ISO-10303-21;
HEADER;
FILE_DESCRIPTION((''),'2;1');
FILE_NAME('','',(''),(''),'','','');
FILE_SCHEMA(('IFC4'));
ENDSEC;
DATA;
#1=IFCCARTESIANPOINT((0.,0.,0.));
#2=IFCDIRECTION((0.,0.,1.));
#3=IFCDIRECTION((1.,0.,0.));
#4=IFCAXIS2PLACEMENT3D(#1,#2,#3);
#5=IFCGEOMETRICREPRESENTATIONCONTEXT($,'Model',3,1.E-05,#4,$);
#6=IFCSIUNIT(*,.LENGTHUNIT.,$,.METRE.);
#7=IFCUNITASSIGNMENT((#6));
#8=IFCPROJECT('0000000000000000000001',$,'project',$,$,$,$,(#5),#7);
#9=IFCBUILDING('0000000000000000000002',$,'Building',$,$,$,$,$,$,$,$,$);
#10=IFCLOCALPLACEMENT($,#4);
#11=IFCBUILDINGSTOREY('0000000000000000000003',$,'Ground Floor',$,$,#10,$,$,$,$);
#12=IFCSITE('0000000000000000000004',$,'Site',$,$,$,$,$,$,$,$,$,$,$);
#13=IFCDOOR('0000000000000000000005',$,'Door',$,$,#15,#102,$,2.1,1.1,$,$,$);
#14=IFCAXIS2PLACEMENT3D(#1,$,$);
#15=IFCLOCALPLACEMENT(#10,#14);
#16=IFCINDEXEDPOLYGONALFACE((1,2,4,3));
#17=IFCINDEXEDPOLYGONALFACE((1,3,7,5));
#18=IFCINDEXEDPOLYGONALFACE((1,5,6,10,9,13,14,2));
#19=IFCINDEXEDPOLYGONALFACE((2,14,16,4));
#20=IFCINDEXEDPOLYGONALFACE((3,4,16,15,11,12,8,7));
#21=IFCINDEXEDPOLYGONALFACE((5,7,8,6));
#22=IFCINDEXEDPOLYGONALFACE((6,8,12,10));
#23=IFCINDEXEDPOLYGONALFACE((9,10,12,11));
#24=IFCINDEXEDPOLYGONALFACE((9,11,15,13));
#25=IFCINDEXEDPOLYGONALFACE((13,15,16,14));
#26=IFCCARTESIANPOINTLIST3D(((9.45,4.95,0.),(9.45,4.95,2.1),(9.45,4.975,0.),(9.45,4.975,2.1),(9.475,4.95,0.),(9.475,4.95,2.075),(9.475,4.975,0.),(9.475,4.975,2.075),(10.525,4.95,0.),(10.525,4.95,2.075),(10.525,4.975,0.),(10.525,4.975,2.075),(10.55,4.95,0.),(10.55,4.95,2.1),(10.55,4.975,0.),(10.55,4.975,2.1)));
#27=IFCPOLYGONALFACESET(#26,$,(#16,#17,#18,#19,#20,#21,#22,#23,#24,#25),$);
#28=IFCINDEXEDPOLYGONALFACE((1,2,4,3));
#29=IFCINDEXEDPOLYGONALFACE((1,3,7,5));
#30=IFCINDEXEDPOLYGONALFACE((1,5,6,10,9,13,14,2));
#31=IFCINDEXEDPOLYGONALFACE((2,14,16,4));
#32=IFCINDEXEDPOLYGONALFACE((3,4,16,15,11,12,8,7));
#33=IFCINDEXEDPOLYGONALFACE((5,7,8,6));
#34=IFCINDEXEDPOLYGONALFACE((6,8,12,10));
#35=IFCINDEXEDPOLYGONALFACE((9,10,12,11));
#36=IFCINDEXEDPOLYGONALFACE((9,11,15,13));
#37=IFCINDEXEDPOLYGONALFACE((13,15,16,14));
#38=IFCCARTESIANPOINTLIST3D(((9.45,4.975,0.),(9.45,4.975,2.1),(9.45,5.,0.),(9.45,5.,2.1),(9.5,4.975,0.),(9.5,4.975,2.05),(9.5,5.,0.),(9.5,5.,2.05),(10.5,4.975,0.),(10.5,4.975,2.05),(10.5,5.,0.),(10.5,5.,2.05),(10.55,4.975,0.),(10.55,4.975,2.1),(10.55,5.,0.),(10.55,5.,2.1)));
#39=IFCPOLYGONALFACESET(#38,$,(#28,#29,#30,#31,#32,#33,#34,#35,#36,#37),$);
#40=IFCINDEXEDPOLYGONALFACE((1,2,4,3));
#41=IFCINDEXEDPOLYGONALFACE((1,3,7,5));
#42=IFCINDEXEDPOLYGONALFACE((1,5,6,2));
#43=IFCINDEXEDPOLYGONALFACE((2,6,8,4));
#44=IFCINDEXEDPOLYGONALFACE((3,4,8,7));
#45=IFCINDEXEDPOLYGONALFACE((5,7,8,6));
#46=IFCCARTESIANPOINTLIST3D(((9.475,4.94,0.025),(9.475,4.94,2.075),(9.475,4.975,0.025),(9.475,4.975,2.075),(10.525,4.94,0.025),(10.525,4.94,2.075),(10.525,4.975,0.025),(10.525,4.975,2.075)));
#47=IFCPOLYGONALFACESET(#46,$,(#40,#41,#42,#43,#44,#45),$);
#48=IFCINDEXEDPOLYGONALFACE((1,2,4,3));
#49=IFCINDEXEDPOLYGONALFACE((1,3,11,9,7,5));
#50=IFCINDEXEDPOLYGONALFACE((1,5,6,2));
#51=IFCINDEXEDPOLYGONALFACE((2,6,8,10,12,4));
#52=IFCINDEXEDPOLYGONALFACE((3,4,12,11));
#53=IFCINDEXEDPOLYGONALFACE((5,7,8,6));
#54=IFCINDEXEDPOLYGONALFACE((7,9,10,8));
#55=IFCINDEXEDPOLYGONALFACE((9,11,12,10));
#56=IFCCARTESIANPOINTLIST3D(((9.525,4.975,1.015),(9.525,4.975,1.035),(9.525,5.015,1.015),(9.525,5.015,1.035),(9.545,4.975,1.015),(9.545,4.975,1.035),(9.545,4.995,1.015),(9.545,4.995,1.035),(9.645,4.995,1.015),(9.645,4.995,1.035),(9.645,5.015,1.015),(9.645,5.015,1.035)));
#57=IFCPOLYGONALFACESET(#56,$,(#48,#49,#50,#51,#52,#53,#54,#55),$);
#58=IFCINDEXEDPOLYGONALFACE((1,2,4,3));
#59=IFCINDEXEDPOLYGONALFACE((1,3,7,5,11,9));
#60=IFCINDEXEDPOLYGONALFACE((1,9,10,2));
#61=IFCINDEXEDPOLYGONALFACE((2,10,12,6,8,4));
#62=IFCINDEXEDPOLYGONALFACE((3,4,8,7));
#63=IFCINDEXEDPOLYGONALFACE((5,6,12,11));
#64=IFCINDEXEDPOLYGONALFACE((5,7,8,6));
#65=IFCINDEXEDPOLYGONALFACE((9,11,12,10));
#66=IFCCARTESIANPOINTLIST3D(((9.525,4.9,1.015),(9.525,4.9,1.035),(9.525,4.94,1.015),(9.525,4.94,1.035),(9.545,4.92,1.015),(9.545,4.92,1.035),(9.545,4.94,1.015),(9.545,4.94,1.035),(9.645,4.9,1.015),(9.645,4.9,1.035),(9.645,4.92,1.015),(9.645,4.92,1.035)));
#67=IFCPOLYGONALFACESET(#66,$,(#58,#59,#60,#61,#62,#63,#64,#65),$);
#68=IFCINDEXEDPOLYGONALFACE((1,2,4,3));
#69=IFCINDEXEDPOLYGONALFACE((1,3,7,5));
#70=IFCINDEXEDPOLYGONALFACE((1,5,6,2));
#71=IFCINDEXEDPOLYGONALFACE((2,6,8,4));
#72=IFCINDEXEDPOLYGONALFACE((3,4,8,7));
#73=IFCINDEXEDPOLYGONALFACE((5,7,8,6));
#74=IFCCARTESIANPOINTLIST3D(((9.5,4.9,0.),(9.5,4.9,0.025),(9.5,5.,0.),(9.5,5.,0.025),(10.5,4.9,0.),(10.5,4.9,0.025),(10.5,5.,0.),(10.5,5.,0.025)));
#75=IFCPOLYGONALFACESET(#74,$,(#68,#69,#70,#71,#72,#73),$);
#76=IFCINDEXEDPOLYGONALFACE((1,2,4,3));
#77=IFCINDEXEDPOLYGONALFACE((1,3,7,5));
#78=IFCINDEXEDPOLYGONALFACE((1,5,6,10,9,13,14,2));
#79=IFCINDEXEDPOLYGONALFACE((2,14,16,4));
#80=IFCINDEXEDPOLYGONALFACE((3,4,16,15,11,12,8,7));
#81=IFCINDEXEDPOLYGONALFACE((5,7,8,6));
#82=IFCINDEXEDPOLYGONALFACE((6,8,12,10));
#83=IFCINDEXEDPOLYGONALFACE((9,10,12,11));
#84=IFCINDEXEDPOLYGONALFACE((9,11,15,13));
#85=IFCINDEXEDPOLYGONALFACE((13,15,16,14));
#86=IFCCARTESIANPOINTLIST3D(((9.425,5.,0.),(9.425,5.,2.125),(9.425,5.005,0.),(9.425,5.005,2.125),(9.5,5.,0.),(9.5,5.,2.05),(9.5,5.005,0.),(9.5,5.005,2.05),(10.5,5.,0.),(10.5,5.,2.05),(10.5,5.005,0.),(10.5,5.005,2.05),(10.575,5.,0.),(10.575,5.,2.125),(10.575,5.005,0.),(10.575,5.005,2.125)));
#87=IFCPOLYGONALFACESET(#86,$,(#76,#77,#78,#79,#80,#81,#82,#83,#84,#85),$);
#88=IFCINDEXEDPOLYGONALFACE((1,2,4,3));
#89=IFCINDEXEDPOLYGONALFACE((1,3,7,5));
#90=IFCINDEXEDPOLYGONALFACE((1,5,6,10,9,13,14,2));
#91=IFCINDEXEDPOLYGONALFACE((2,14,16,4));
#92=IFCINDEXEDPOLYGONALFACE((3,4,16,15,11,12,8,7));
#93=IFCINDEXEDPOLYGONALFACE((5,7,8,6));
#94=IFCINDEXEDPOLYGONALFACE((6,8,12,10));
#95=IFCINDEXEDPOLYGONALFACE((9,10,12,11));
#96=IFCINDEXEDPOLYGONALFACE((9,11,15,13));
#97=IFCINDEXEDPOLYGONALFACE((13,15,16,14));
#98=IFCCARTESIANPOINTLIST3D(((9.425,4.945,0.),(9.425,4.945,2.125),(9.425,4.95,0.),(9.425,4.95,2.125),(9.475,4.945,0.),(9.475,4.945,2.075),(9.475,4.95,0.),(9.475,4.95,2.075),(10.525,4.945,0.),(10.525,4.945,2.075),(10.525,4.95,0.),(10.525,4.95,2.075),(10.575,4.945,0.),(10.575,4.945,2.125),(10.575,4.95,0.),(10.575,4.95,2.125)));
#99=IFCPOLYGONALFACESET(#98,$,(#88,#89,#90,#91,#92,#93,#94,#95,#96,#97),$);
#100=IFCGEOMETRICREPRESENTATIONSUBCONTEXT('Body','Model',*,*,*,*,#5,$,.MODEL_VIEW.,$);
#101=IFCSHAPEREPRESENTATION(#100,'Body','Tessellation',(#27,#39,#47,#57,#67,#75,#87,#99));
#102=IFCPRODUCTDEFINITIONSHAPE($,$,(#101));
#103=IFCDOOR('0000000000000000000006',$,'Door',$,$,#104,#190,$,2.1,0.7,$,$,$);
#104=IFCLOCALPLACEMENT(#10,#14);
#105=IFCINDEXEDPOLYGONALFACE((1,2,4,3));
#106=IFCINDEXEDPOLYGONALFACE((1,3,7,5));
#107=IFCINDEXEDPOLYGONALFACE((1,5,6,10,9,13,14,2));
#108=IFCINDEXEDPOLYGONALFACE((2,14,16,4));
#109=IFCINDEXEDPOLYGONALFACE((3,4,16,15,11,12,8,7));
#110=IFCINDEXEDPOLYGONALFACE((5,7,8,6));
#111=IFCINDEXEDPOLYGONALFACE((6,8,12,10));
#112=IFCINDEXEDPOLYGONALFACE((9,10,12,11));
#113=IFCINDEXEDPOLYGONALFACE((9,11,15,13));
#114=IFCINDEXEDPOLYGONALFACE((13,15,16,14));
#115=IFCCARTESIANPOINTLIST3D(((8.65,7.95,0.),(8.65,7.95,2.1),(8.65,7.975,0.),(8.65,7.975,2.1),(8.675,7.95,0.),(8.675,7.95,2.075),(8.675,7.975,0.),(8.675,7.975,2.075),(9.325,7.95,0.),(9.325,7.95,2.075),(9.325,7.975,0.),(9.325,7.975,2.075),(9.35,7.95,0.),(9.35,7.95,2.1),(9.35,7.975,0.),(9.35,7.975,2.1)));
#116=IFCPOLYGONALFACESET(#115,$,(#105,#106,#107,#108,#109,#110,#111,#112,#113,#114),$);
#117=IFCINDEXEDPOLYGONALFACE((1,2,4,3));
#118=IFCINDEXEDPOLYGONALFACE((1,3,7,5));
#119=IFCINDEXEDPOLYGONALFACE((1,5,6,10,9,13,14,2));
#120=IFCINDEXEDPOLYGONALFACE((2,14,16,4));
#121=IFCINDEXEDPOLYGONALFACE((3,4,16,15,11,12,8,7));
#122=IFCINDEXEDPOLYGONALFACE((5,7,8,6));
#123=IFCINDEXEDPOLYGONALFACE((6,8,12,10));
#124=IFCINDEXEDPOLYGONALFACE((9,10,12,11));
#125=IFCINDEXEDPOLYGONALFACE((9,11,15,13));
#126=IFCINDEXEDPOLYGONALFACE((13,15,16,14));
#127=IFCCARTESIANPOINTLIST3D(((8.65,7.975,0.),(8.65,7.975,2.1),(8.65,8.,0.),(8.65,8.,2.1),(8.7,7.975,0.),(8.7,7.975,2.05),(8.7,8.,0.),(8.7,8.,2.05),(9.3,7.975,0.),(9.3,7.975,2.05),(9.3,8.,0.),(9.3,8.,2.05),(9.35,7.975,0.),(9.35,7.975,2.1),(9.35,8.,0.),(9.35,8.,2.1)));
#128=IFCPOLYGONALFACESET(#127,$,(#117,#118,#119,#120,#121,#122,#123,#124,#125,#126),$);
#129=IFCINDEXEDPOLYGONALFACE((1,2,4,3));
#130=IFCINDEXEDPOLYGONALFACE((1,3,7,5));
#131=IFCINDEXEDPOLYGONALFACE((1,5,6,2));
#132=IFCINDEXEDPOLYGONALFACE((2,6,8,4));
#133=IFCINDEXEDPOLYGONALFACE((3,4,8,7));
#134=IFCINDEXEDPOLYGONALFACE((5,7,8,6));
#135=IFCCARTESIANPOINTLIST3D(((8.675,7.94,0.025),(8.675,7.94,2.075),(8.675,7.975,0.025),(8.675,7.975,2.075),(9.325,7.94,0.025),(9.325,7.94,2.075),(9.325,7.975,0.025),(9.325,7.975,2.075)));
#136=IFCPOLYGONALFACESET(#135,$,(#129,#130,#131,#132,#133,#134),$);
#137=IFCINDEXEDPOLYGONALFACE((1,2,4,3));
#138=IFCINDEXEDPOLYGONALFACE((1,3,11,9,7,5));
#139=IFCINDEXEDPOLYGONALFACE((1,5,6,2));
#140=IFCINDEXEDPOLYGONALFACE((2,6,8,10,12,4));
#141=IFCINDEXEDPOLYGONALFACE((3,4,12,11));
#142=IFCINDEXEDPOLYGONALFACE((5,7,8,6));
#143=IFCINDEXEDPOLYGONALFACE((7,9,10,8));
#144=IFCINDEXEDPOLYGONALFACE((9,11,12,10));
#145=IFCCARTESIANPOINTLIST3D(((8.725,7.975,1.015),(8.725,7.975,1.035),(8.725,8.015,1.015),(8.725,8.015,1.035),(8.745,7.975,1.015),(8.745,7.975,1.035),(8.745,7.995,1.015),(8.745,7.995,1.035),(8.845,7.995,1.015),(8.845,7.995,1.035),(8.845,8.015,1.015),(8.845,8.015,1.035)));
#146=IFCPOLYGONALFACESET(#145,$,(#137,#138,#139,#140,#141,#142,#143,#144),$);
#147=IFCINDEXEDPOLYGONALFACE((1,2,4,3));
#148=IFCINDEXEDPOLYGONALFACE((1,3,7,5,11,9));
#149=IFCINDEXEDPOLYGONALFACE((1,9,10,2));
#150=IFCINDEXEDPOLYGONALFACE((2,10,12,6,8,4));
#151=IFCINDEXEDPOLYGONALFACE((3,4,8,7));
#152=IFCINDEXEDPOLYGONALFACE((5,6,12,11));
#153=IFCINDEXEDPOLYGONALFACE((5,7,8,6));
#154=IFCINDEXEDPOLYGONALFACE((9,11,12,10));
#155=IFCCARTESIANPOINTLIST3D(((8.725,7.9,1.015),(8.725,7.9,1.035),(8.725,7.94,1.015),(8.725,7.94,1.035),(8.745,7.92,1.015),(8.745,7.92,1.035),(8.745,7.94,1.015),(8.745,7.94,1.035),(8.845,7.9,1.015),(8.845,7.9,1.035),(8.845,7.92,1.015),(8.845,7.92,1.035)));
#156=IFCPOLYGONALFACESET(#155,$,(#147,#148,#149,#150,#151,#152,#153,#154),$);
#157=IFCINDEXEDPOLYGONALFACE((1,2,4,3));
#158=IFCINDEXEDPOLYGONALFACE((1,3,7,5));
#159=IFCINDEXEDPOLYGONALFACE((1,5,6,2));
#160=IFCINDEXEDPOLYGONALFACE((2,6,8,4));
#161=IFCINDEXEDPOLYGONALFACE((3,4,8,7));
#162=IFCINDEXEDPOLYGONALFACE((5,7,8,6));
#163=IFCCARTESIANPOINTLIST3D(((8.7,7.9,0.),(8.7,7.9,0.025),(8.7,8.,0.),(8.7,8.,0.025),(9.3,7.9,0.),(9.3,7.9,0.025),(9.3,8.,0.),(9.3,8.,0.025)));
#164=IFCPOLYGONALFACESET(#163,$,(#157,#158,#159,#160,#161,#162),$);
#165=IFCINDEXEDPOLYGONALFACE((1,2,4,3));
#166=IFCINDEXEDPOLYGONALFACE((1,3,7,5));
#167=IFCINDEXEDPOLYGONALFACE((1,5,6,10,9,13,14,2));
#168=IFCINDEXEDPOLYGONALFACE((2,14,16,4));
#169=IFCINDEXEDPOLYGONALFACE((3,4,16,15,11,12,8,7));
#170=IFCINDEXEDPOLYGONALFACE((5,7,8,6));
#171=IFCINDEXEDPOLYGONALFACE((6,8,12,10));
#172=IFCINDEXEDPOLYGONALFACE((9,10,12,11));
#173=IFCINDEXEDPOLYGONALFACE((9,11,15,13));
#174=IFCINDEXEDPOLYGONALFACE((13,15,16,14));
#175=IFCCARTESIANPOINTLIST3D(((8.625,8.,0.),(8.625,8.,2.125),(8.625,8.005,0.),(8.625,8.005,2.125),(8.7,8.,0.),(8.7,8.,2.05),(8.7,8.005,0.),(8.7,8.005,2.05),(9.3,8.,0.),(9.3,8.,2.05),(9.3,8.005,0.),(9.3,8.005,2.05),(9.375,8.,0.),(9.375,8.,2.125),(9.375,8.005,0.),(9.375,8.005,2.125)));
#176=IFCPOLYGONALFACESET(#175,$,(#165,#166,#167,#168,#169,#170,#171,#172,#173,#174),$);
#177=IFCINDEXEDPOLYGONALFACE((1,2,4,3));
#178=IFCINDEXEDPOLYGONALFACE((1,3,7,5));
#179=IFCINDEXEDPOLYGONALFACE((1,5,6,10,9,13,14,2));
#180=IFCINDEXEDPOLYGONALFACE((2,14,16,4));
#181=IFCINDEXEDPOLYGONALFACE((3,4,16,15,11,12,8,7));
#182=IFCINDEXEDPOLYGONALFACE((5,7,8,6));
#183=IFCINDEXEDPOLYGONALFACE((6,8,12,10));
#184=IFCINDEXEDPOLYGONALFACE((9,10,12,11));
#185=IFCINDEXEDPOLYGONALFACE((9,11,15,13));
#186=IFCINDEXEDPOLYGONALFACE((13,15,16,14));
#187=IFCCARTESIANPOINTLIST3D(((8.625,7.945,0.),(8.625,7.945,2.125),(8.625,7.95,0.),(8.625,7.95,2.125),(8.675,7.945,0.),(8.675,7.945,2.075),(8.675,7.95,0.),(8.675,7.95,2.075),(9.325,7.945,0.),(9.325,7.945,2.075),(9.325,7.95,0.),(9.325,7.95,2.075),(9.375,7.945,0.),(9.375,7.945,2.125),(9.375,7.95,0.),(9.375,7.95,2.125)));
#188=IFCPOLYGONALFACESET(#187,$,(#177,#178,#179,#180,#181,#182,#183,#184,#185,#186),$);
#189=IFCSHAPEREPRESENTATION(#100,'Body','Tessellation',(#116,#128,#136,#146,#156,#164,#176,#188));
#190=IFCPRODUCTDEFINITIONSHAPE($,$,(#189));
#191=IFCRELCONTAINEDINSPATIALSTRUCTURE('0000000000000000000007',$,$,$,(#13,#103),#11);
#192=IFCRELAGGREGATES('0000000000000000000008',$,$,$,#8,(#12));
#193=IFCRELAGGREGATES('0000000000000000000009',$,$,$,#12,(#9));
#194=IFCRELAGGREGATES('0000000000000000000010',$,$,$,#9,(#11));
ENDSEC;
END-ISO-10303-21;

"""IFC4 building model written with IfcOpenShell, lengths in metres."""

from ifc_helpers import new_model, si_unit, frame, origin_with_axes, place, context, subcontext, project, spatial, line, indexed_curve, outline, extrude, element, save


model = new_model("IFC4")

# Units and contexts
model_context = context("Model", 3, precision=1e-05, world=origin_with_axes())
body_context = subcontext(model_context, "Body", "Model", "MODEL_VIEW")
ifc_project = project(units=[si_unit("LENGTHUNIT", "METRE")], contexts=[model_context])

# Site, building, storey
site = spatial("IfcSite", under=ifc_project, Name="Site")
building = spatial("IfcBuilding", under=site, Name="Building")
storey_placement = place(None, origin_with_axes())
storey = spatial("IfcBuildingStorey", under=building, at=storey_placement, Name="Ground Floor")

# Doors
door_1_placement = place(storey_placement, frame((10.55, 5.0, 0.0), z_axis=(0.0, 0.0, 1.0), x_axis=(-1.0, 0.0, 0.0)))
element("IfcDoor", 1, at=door_1_placement, inside=storey, Name="Door", OverallHeight=2.1, OverallWidth=1.1, context=body_context, shape_type="SweptSolid", body=[
    extrude(outline(indexed_curve([(0.0, 0.0), (0.0, 2.1), (1.1, 2.1), (1.1, 0.0), (1.075, 0.0), (1.075, 2.075), (0.025, 2.075), (0.025, 0.0)], segments=[line(1, 2, 3, 4, 5, 6, 7, 8, 1)])), frame((0.0, 0.025, 0.0), z_axis=(0.0, -1.0, 0.0), x_axis=(1.0, 0.0, 0.0)), (0.0, 0.0, -1.0), 0.025),
    extrude(outline(indexed_curve([(0.0, 0.0), (0.0, 2.1), (1.1, 2.1), (1.1, 0.0), (1.05, 0.0), (1.05, 2.05), (0.05, 2.05), (0.05, 0.0)], segments=[line(1, 2, 3, 4, 5, 6, 7, 8, 1)])), frame((0.0, 0.0, 0.0), z_axis=(0.0, -1.0, 0.0), x_axis=(1.0, 0.0, 0.0)), (0.0, 0.0, -1.0), 0.025),
    extrude(outline(indexed_curve([(0.0, 0.0), (1.05, 0.0), (1.05, 0.035), (0.0, 0.035)], segments=[line(1, 2, 3, 4, 1)])), frame((0.025, 0.025, 0.025), z_axis=(0.0, 0.0, 1.0), x_axis=(1.0, 0.0, 0.0)), (0.0, 0.0, 1.0), 2.05),
    extrude(outline(indexed_curve([(0.0, 0.0), (0.0, -0.04), (-0.12, -0.04), (-0.12, -0.02), (-0.02, -0.02), (-0.02, 0.0)], segments=[line(1, 2, 3, 4, 5, 6, 1)])), frame((1.025, 0.025, 1.015), z_axis=(0.0, 0.0, 1.0), x_axis=(1.0, 0.0, 0.0)), (0.0, 0.0, 1.0), 0.02),
    extrude(outline(indexed_curve([(0.0, 0.0), (0.0, 0.04), (-0.12, 0.04), (-0.12, 0.02), (-0.02, 0.02), (-0.02, 0.0)], segments=[line(1, 2, 3, 4, 5, 6, 1)])), frame((1.025, 0.06, 1.015), z_axis=(0.0, 0.0, 1.0), x_axis=(1.0, 0.0, 0.0)), (0.0, 0.0, 1.0), 0.02),
    extrude(outline(indexed_curve([(0.0, 0.0), (1.0, 0.0), (1.0, 0.1), (0.0, 0.1)], segments=[line(1, 2, 3, 4, 1)])), frame((0.05, 0.0, 0.0), z_axis=(0.0, 0.0, 1.0), x_axis=(1.0, 0.0, 0.0)), (0.0, 0.0, 1.0), 0.025),
    extrude(outline(indexed_curve([(0.0, 0.0), (0.0, 2.125), (1.15, 2.125), (1.15, 0.0), (1.075, 0.0), (1.075, 2.05), (0.075, 2.05), (0.075, 0.0)], segments=[line(1, 2, 3, 4, 5, 6, 7, 8, 1)])), frame((-0.025, -0.005, 0.0), z_axis=(0.0, -1.0, 0.0), x_axis=(1.0, 0.0, 0.0)), (0.0, 0.0, -1.0), 0.005),
    extrude(outline(indexed_curve([(0.0, 0.0), (0.0, 2.125), (1.15, 2.125), (1.15, 0.0), (1.1, 0.0), (1.1, 2.075), (0.05, 2.075), (0.05, 0.0)], segments=[line(1, 2, 3, 4, 5, 6, 7, 8, 1)])), frame((-0.025, 0.05, 0.0), z_axis=(0.0, -1.0, 0.0), x_axis=(1.0, 0.0, 0.0)), (0.0, 0.0, -1.0), 0.005),
])
door_2_placement = place(storey_placement, frame((9.35, 8.0, 0.0), z_axis=(0.0, 0.0, 1.0), x_axis=(-1.0, 0.0, 0.0)))
element("IfcDoor", 2, at=door_2_placement, inside=storey, Name="Door", OverallHeight=2.1, OverallWidth=0.7, context=body_context, shape_type="SweptSolid", body=[
    extrude(outline(indexed_curve([(0.0, 0.0), (0.0, 2.1), (0.7, 2.1), (0.7, 0.0), (0.675, 0.0), (0.675, 2.075), (0.025, 2.075), (0.025, 0.0)], segments=[line(1, 2, 3, 4, 5, 6, 7, 8, 1)])), frame((0.0, 0.025, 0.0), z_axis=(0.0, -1.0, 0.0), x_axis=(1.0, 0.0, 0.0)), (0.0, 0.0, -1.0), 0.025),
    extrude(outline(indexed_curve([(0.0, 0.0), (0.0, 2.1), (0.7, 2.1), (0.7, 0.0), (0.65, 0.0), (0.65, 2.05), (0.05, 2.05), (0.05, 0.0)], segments=[line(1, 2, 3, 4, 5, 6, 7, 8, 1)])), frame((0.0, 0.0, 0.0), z_axis=(0.0, -1.0, 0.0), x_axis=(1.0, 0.0, 0.0)), (0.0, 0.0, -1.0), 0.025),
    extrude(outline(indexed_curve([(0.0, 0.0), (0.65, 0.0), (0.65, 0.035), (0.0, 0.035)], segments=[line(1, 2, 3, 4, 1)])), frame((0.025, 0.025, 0.025), z_axis=(0.0, 0.0, 1.0), x_axis=(1.0, 0.0, 0.0)), (0.0, 0.0, 1.0), 2.05),
    extrude(outline(indexed_curve([(0.0, 0.0), (0.0, -0.04), (-0.12, -0.04), (-0.12, -0.02), (-0.02, -0.02), (-0.02, 0.0)], segments=[line(1, 2, 3, 4, 5, 6, 1)])), frame((0.625, 0.025, 1.015), z_axis=(0.0, 0.0, 1.0), x_axis=(1.0, 0.0, 0.0)), (0.0, 0.0, 1.0), 0.02),
    extrude(outline(indexed_curve([(0.0, 0.0), (0.0, 0.04), (-0.12, 0.04), (-0.12, 0.02), (-0.02, 0.02), (-0.02, 0.0)], segments=[line(1, 2, 3, 4, 5, 6, 1)])), frame((0.625, 0.06, 1.015), z_axis=(0.0, 0.0, 1.0), x_axis=(1.0, 0.0, 0.0)), (0.0, 0.0, 1.0), 0.02),
    extrude(outline(indexed_curve([(0.0, 0.0), (0.6, 0.0), (0.6, 0.1), (0.0, 0.1)], segments=[line(1, 2, 3, 4, 1)])), frame((0.05, 0.0, 0.0), z_axis=(0.0, 0.0, 1.0), x_axis=(1.0, 0.0, 0.0)), (0.0, 0.0, 1.0), 0.025),
    extrude(outline(indexed_curve([(0.0, 0.0), (0.0, 2.125), (0.75, 2.125), (0.75, 0.0), (0.675, 0.0), (0.675, 2.05), (0.075, 2.05), (0.075, 0.0)], segments=[line(1, 2, 3, 4, 5, 6, 7, 8, 1)])), frame((-0.025, -0.005, 0.0), z_axis=(0.0, -1.0, 0.0), x_axis=(1.0, 0.0, 0.0)), (0.0, 0.0, -1.0), 0.005),
    extrude(outline(indexed_curve([(0.0, 0.0), (0.0, 2.125), (0.75, 2.125), (0.75, 0.0), (0.7, 0.0), (0.7, 2.075), (0.05, 2.075), (0.05, 0.0)], segments=[line(1, 2, 3, 4, 5, 6, 7, 8, 1)])), frame((-0.025, 0.05, 0.0), z_axis=(0.0, -1.0, 0.0), x_axis=(1.0, 0.0, 0.0)), (0.0, 0.0, -1.0), 0.005),
])

save(model, "model.ifc")
